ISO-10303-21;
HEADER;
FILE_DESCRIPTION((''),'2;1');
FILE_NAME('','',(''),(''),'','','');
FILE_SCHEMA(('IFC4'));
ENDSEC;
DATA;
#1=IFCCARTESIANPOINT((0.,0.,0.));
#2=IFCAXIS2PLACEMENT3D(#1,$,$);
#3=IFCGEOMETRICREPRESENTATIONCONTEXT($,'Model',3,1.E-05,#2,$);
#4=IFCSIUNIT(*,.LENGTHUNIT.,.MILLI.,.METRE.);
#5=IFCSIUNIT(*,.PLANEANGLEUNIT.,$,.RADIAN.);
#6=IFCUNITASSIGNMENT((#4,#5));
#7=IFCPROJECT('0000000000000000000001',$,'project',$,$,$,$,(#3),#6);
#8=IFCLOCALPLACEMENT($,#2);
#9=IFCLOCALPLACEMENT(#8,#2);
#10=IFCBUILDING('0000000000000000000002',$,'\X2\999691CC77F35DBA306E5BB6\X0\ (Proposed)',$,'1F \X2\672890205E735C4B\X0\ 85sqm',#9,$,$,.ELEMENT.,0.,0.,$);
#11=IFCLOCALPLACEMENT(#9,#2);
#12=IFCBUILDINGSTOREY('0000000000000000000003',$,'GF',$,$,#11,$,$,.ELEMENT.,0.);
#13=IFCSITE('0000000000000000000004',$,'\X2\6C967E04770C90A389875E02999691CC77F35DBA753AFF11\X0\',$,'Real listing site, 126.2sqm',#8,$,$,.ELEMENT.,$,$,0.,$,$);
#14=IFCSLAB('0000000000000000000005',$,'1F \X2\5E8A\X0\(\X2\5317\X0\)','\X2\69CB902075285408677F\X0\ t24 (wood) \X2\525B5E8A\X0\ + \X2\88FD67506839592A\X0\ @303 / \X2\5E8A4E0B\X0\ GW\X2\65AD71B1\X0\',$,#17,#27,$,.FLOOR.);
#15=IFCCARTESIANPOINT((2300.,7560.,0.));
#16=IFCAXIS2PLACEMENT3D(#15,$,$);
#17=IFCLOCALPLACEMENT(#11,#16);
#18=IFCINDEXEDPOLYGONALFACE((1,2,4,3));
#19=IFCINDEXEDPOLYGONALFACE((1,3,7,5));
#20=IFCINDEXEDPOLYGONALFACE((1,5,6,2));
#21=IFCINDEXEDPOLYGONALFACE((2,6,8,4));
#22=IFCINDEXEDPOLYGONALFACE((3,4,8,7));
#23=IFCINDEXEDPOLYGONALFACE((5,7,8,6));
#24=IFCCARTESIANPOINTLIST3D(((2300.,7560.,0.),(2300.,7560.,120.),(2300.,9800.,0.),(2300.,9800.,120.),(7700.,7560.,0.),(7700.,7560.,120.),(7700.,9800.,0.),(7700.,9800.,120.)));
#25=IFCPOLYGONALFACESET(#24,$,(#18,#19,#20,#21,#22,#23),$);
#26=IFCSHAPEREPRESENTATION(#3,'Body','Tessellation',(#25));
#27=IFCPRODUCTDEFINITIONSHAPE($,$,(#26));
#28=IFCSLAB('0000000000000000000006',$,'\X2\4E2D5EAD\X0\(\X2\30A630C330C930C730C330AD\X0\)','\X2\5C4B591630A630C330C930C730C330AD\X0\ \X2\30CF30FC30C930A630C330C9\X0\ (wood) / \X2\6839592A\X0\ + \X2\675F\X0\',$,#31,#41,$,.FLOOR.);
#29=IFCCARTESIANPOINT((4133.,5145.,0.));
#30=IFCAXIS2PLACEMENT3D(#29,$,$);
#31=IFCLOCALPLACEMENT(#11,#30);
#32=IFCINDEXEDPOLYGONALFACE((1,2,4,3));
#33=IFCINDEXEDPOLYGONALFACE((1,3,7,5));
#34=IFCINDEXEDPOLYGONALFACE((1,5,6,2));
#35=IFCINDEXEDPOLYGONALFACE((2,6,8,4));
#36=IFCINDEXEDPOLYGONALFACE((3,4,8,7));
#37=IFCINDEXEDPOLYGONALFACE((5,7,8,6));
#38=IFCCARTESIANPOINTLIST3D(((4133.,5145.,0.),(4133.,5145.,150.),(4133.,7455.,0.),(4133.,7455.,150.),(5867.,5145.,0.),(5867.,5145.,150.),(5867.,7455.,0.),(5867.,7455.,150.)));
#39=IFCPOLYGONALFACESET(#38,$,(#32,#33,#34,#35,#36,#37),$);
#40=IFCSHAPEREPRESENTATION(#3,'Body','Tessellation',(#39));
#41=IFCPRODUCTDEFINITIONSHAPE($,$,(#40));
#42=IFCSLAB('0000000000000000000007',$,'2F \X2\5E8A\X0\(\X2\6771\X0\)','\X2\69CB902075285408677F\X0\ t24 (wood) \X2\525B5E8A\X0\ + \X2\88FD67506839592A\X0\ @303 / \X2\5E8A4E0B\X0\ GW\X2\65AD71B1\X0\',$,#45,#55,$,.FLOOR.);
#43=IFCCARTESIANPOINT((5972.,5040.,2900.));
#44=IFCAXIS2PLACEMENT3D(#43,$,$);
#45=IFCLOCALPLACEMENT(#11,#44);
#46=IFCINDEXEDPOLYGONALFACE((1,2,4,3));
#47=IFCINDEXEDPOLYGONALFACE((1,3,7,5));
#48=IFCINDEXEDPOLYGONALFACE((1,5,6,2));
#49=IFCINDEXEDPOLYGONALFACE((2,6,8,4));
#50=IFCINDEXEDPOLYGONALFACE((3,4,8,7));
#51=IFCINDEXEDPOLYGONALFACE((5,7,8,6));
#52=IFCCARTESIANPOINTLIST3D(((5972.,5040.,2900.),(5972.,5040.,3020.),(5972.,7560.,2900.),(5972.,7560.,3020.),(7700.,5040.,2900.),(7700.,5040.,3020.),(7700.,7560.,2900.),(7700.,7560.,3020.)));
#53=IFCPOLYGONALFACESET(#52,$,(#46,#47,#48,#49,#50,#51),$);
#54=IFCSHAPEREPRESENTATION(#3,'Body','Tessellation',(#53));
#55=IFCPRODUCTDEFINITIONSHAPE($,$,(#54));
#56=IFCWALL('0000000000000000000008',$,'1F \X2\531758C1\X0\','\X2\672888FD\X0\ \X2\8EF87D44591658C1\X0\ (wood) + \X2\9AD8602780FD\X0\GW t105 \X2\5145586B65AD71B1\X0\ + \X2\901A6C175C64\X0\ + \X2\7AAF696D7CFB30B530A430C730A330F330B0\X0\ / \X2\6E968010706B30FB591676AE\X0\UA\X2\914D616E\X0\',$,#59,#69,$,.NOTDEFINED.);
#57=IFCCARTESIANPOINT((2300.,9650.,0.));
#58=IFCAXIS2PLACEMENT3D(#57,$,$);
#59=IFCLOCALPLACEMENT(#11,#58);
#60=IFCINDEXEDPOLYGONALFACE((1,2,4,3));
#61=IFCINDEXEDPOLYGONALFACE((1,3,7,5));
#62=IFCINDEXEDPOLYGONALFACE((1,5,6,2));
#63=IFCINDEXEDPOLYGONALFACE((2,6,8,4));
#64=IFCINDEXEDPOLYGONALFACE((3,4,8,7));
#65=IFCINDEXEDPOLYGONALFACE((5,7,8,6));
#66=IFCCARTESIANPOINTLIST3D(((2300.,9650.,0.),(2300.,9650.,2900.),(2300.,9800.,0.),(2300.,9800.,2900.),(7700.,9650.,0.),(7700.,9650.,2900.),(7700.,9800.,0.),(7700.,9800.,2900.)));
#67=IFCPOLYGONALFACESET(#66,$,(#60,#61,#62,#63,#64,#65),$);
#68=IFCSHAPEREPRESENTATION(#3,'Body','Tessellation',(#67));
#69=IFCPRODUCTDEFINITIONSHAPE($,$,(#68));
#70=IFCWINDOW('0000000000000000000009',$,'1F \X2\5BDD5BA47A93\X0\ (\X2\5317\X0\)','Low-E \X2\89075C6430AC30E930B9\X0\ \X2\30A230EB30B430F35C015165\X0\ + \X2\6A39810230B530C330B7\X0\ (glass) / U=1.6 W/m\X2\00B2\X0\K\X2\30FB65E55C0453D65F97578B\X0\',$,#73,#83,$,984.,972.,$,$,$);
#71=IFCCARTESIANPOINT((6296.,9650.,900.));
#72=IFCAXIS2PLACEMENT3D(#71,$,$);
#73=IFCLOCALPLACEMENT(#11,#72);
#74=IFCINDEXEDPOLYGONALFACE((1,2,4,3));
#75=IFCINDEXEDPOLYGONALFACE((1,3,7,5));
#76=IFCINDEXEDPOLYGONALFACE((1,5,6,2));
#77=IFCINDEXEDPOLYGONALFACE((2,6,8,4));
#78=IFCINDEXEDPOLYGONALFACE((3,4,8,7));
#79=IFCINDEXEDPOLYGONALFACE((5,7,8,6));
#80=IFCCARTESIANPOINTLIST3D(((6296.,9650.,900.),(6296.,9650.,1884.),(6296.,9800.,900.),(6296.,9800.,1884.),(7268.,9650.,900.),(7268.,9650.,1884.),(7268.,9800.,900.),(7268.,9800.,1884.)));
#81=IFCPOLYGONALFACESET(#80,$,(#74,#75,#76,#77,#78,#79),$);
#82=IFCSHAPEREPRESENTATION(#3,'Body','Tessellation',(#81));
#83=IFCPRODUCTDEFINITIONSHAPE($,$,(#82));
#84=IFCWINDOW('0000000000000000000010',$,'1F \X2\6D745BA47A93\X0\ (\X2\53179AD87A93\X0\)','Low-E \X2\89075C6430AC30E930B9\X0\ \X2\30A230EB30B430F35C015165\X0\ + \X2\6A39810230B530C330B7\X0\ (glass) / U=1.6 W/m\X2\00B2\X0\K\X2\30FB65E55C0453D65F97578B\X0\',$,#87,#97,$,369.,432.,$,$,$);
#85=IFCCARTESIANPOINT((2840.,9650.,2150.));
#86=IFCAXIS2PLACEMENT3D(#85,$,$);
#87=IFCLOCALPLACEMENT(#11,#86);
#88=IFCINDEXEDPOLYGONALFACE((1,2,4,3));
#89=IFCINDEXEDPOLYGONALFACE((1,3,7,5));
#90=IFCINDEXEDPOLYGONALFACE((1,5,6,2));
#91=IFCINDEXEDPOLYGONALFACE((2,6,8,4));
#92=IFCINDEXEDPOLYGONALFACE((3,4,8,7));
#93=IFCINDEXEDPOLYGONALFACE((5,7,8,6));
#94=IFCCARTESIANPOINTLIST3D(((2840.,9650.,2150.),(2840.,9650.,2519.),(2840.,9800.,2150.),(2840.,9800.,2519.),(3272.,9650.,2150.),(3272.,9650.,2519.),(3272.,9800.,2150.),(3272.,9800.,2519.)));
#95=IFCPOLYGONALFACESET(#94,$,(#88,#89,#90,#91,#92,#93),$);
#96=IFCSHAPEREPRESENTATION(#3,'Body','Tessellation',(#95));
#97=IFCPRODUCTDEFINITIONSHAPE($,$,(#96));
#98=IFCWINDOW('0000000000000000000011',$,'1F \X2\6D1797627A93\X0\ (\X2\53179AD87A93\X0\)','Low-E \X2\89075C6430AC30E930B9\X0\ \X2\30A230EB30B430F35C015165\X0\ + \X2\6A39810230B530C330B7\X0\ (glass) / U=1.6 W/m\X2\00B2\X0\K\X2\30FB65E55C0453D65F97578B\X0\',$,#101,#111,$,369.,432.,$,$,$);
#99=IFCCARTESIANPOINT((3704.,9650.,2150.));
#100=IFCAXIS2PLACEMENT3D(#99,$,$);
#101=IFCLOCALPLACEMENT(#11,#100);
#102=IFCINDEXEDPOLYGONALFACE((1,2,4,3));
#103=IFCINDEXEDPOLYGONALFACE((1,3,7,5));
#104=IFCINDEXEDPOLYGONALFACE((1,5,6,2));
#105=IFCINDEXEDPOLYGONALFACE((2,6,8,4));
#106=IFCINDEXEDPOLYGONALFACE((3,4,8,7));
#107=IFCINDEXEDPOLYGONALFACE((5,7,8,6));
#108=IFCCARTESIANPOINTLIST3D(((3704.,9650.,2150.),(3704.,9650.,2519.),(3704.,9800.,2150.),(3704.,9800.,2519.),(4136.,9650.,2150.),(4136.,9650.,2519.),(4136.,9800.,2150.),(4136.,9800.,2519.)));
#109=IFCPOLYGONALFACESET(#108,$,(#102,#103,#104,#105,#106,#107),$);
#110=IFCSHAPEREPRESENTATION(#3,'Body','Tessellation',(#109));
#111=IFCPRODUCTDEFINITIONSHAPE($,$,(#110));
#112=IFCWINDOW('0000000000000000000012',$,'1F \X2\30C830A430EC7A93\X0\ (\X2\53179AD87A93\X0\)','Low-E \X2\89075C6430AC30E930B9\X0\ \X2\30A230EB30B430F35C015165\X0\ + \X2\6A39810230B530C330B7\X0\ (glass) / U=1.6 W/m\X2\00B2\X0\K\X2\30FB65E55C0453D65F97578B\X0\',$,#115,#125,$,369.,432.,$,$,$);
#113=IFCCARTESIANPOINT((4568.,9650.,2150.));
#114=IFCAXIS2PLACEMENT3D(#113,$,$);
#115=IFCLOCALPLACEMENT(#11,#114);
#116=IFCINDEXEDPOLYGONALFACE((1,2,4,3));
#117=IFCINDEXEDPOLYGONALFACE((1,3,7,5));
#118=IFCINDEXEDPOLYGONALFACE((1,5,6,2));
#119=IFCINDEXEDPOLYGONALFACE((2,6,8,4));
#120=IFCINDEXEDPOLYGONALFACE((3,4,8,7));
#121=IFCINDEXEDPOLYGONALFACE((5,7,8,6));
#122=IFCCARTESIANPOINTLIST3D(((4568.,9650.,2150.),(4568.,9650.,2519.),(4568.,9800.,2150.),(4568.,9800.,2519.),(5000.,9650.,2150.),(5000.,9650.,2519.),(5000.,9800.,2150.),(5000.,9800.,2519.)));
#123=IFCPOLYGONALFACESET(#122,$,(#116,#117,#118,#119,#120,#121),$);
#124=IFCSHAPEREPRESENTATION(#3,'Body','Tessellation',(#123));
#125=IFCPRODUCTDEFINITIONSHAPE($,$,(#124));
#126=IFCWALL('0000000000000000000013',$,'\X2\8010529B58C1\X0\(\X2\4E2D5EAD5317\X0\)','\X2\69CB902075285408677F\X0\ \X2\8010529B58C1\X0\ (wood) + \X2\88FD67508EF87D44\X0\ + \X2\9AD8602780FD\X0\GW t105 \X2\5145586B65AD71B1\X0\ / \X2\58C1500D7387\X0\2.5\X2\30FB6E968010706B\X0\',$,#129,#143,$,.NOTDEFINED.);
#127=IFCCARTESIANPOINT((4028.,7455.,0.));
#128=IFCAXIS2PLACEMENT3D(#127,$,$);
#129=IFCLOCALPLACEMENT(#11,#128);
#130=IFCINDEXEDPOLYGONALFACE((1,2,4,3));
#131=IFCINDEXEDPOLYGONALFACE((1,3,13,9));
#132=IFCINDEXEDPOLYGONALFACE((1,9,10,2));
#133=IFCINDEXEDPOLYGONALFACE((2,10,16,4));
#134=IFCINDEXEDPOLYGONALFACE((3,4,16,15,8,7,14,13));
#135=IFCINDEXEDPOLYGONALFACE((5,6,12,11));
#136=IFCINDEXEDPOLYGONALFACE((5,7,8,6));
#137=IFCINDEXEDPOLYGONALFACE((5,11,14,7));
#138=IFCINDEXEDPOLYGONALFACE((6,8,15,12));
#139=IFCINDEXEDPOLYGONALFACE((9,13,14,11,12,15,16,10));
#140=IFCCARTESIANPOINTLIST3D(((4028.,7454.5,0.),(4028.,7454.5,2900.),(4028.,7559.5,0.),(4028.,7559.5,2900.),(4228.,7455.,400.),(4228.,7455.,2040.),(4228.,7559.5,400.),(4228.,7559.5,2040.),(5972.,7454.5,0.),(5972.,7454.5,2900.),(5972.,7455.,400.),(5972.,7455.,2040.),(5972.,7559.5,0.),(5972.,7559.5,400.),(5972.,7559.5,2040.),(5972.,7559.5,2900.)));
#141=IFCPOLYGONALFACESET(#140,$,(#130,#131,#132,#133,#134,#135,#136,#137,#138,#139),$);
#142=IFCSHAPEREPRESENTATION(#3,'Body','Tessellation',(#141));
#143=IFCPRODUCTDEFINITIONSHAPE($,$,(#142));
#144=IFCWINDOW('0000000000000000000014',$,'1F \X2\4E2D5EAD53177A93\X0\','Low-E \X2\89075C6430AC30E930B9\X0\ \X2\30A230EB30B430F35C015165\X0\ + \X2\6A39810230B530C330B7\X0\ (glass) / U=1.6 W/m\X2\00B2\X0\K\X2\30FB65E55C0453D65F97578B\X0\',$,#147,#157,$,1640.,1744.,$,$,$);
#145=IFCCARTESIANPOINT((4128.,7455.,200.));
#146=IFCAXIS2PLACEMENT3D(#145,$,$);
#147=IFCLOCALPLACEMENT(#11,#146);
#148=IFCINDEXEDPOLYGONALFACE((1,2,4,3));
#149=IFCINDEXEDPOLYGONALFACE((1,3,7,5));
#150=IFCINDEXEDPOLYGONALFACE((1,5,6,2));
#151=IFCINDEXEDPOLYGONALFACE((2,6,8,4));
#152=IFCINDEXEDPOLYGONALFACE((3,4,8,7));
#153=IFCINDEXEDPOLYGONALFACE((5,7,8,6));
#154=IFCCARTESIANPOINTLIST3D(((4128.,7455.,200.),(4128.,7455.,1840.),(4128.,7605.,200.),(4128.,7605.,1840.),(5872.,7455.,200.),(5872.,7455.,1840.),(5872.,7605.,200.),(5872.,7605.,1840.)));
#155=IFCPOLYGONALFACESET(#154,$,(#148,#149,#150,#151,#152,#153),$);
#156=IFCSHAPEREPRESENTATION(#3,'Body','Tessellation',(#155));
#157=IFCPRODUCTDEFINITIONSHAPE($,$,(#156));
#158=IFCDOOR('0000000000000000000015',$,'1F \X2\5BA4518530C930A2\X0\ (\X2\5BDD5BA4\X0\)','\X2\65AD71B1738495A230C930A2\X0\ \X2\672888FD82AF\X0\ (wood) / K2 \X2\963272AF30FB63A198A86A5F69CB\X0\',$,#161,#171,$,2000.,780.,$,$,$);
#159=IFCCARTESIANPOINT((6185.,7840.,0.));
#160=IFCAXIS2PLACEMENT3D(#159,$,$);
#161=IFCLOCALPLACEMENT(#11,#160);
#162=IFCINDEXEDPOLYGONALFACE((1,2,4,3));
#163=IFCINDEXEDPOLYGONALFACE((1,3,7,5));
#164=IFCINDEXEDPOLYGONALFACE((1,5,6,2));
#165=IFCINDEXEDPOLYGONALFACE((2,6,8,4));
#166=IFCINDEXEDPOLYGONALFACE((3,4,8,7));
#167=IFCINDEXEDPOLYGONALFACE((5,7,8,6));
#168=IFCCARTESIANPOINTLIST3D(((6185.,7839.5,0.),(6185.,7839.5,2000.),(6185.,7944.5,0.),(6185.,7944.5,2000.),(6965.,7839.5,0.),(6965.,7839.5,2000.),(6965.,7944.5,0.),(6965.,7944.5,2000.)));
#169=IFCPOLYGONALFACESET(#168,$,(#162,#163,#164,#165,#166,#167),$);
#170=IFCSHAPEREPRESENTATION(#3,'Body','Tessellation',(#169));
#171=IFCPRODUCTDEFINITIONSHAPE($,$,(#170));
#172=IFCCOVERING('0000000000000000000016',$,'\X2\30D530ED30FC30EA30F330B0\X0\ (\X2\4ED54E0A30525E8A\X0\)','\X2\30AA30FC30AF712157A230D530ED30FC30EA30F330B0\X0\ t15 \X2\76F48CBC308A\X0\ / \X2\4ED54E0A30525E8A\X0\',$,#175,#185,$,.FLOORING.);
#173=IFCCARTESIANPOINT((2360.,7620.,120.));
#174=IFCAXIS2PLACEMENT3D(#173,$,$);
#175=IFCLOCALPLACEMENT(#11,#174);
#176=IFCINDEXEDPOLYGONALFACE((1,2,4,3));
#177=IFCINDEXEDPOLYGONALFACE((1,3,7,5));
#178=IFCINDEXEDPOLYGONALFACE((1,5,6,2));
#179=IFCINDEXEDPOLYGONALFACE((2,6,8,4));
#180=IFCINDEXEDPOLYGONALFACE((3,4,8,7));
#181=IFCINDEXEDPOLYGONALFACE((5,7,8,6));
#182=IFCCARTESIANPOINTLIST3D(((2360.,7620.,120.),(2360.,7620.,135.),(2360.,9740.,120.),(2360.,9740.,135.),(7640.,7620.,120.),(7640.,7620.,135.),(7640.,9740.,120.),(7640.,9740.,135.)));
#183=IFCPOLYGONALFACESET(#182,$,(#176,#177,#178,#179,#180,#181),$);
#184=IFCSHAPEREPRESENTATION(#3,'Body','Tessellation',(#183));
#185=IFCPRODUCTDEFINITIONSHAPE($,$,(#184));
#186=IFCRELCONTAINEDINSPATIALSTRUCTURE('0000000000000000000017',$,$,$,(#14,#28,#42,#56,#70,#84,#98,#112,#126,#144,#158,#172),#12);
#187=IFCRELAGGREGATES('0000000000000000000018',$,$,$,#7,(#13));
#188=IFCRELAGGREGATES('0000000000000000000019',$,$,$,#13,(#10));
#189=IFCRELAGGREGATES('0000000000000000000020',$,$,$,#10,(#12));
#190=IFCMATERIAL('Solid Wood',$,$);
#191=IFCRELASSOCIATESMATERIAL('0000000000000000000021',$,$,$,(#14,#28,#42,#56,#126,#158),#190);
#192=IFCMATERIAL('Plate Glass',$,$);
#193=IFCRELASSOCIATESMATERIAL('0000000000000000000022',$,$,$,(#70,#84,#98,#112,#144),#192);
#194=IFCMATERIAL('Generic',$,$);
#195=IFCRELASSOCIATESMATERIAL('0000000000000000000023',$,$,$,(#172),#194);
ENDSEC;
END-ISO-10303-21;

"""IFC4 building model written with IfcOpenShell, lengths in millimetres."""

from ifc_helpers import new_model, si_unit, frame, frame_2d, origin, place, context, project, spatial, rectangle, extrude, material, element, fill, save


model = new_model("IFC4")

# Units and contexts
model_context = context("Model", 3, precision=1e-05, world=origin())
ifc_project = project(units=[si_unit("LENGTHUNIT", "METRE", prefix="MILLI"), si_unit("PLANEANGLEUNIT", "RADIAN")], contexts=[model_context])

# Site, building, storey
site_placement = place(None, origin())
site = spatial("IfcSite", under=ifc_project, at=site_placement, Name="沖縄県那覇市首里石嶺町１", ObjectType="Real listing site, 126.2sqm", CompositionType="ELEMENT", RefElevation=0.0)
building_placement = place(site_placement, origin())
building = spatial("IfcBuilding", under=site, at=building_placement, Name="首里石嶺の家 (Proposed)", ObjectType="1F 木造平屋 85sqm", CompositionType="ELEMENT", ElevationOfRefHeight=0.0, ElevationOfTerrain=0.0)
storey_placement = place(building_placement, origin())
storey = spatial("IfcBuildingStorey", under=building, at=storey_placement, Name="GF", CompositionType="ELEMENT", Elevation=0.0)

# Slabs
ifc_material_1 = material(Name="Solid Wood")
slab_1_placement = place(storey_placement, frame((2300.0, 7560.0, 0.0)))
element("IfcSlab", 1, at=slab_1_placement, inside=storey, material=ifc_material_1, Name="1F 床(北)", Description="構造用合板 t24 (wood) 剛床 + 製材根太 @303 / 床下 GW断熱", PredefinedType="FLOOR", context=model_context, shape_type="SweptSolid", body=[
    extrude(rectangle(XDim=5400.0, YDim=2240.0, at=frame_2d((2700.0, 1120.0))), frame((2300.0, 7560.0, 0.0)), (0.0, 0.0, 1.0), 120.0),
])
slab_2_placement = place(storey_placement, frame((4133.0, 5145.0, 0.0)))
element("IfcSlab", 2, at=slab_2_placement, inside=storey, material=ifc_material_1, Name="中庭(ウッドデッキ)", Description="屋外ウッドデッキ ハードウッド (wood) / 根太 + 束", PredefinedType="FLOOR", context=model_context, shape_type="SweptSolid", body=[
    extrude(rectangle(XDim=1734.0, YDim=2310.0, at=frame_2d((867.0, 1155.0))), frame((4133.0, 5145.0, 0.0)), (0.0, 0.0, 1.0), 150.0),
])
slab_3_placement = place(storey_placement, frame((5972.0, 5040.0, 2900.0)))
element("IfcSlab", 3, at=slab_3_placement, inside=storey, material=ifc_material_1, Name="2F 床(東)", Description="構造用合板 t24 (wood) 剛床 + 製材根太 @303 / 床下 GW断熱", PredefinedType="FLOOR", context=model_context, shape_type="SweptSolid", body=[
    extrude(rectangle(XDim=1728.0, YDim=2520.0, at=frame_2d((864.0, 1260.0))), frame((5972.0, 5040.0, 2900.0)), (0.0, 0.0, 1.0), 120.0),
])

# Wall, openings, windows
wall_1_placement = place(storey_placement, frame((2300.0, 9650.0, 0.0)))
wall_1 = element("IfcWall", 4, at=wall_1_placement, inside=storey, material=ifc_material_1, Name="1F 北壁", Description="木製 軸組外壁 (wood) + 高性能GW t105 充填断熱 + 通気層 + 窯業系サイディング / 準耐火・外皮UA配慮", PredefinedType="NOTDEFINED", context=model_context, shape_type="SweptSolid", body=[
    extrude(rectangle(XDim=5400.0, YDim=150.0, at=frame_2d((2700.0, 75.0))), frame((2300.0, 9650.0, 0.0)), (0.0, 0.0, 1.0), 2900.0),
])
opening_1_placement = place(storey_placement, frame((6296.0, 9650.0, 900.0)))
opening_1 = element("IfcOpeningElement", 5, at=opening_1_placement, cuts=wall_1, PredefinedType="NOTDEFINED", context=model_context, shape_type="SweptSolid", body=[
    extrude(rectangle(XDim=972.0, YDim=150.0, at=frame_2d((486.0, 75.0))), frame((6296.0, 9650.0, 900.0)), (0.0, 0.0, 1.0), 984.0),
])
opening_2_placement = place(storey_placement, frame((2840.0, 9650.0, 2150.0)))
opening_2 = element("IfcOpeningElement", 6, at=opening_2_placement, cuts=wall_1, PredefinedType="NOTDEFINED", context=model_context, shape_type="SweptSolid", body=[
    extrude(rectangle(XDim=432.0, YDim=150.0, at=frame_2d((216.0, 75.0))), frame((2840.0, 9650.0, 2150.0)), (0.0, 0.0, 1.0), 369.0),
])
opening_3_placement = place(storey_placement, frame((3704.0, 9650.0, 2150.0)))
opening_3 = element("IfcOpeningElement", 7, at=opening_3_placement, cuts=wall_1, PredefinedType="NOTDEFINED", context=model_context, shape_type="SweptSolid", body=[
    extrude(rectangle(XDim=432.0, YDim=150.0, at=frame_2d((216.0, 75.0))), frame((3704.0, 9650.0, 2150.0)), (0.0, 0.0, 1.0), 369.0),
])
opening_4_placement = place(storey_placement, frame((4568.0, 9650.0, 2150.0)))
opening_4 = element("IfcOpeningElement", 8, at=opening_4_placement, cuts=wall_1, PredefinedType="NOTDEFINED", context=model_context, shape_type="SweptSolid", body=[
    extrude(rectangle(XDim=432.0, YDim=150.0, at=frame_2d((216.0, 75.0))), frame((4568.0, 9650.0, 2150.0)), (0.0, 0.0, 1.0), 369.0),
])
ifc_material_2 = material(Name="Plate Glass")
window_1_placement = place(storey_placement, frame((6296.0, 9650.0, 900.0)))
window_1 = element("IfcWindow", 9, at=window_1_placement, inside=storey, material=ifc_material_2, Name="1F 寝室窓 (北)", Description="Low-E 複層ガラス アルゴン封入 + 樹脂サッシ (glass) / U=1.6 W/m²K・日射取得型", OverallHeight=984.0, OverallWidth=972.0, context=model_context, shape_type="SweptSolid", body=[
    extrude(rectangle(XDim=972.0, YDim=150.0, at=frame_2d((486.0, 75.0))), frame((6296.0, 9650.0, 900.0)), (0.0, 0.0, 1.0), 984.0),
])
fill(opening_1, window_1)
window_2_placement = place(storey_placement, frame((2840.0, 9650.0, 2150.0)))
window_2 = element("IfcWindow", 10, at=window_2_placement, inside=storey, material=ifc_material_2, Name="1F 浴室窓 (北高窓)", Description="Low-E 複層ガラス アルゴン封入 + 樹脂サッシ (glass) / U=1.6 W/m²K・日射取得型", OverallHeight=369.0, OverallWidth=432.0, context=model_context, shape_type="SweptSolid", body=[
    extrude(rectangle(XDim=432.0, YDim=150.0, at=frame_2d((216.0, 75.0))), frame((2840.0, 9650.0, 2150.0)), (0.0, 0.0, 1.0), 369.0),
])
fill(opening_2, window_2)
window_3_placement = place(storey_placement, frame((3704.0, 9650.0, 2150.0)))
window_3 = element("IfcWindow", 11, at=window_3_placement, inside=storey, material=ifc_material_2, Name="1F 洗面窓 (北高窓)", Description="Low-E 複層ガラス アルゴン封入 + 樹脂サッシ (glass) / U=1.6 W/m²K・日射取得型", OverallHeight=369.0, OverallWidth=432.0, context=model_context, shape_type="SweptSolid", body=[
    extrude(rectangle(XDim=432.0, YDim=150.0, at=frame_2d((216.0, 75.0))), frame((3704.0, 9650.0, 2150.0)), (0.0, 0.0, 1.0), 369.0),
])
fill(opening_3, window_3)
window_4_placement = place(storey_placement, frame((4568.0, 9650.0, 2150.0)))
window_4 = element("IfcWindow", 12, at=window_4_placement, inside=storey, material=ifc_material_2, Name="1F トイレ窓 (北高窓)", Description="Low-E 複層ガラス アルゴン封入 + 樹脂サッシ (glass) / U=1.6 W/m²K・日射取得型", OverallHeight=369.0, OverallWidth=432.0, context=model_context, shape_type="SweptSolid", body=[
    extrude(rectangle(XDim=432.0, YDim=150.0, at=frame_2d((216.0, 75.0))), frame((4568.0, 9650.0, 2150.0)), (0.0, 0.0, 1.0), 369.0),
])
fill(opening_4, window_4)

# Wall, opening, window
wall_2_placement = place(storey_placement, frame((4028.0, 7455.0, 0.0)))
wall_2 = element("IfcWall", 13, at=wall_2_placement, inside=storey, material=ifc_material_1, Name="耐力壁(中庭北)", Description="構造用合板 耐力壁 (wood) + 製材軸組 + 高性能GW t105 充填断熱 / 壁倍率2.5・準耐火", PredefinedType="NOTDEFINED", context=model_context, shape_type="SweptSolid", body=[
    extrude(rectangle(XDim=1944.0, YDim=105.0, at=frame_2d((972.0, 52.0))), frame((4028.0, 7455.0, 0.0)), (0.0, 0.0, 1.0), 2900.0),
])
opening_5_placement = place(storey_placement, frame((4128.0, 7455.0, 200.0)))
opening_5 = element("IfcOpeningElement", 14, at=opening_5_placement, cuts=wall_2, PredefinedType="NOTDEFINED", context=model_context, shape_type="SweptSolid", body=[
    extrude(rectangle(XDim=1744.0, YDim=150.0, at=frame_2d((872.0, 75.0))), frame((4128.0, 7455.0, 200.0)), (0.0, 0.0, 1.0), 1640.0),
])
window_5_placement = place(storey_placement, frame((4128.0, 7455.0, 200.0)))
window_5 = element("IfcWindow", 15, at=window_5_placement, inside=storey, material=ifc_material_2, Name="1F 中庭北窓", Description="Low-E 複層ガラス アルゴン封入 + 樹脂サッシ (glass) / U=1.6 W/m²K・日射取得型", OverallHeight=1640.0, OverallWidth=1744.0, context=model_context, shape_type="SweptSolid", body=[
    extrude(rectangle(XDim=1744.0, YDim=150.0, at=frame_2d((872.0, 75.0))), frame((4128.0, 7455.0, 200.0)), (0.0, 0.0, 1.0), 1640.0),
])
fill(opening_5, window_5)

# Door
door_1_placement = place(storey_placement, frame((6185.0, 7840.0, 0.0)))
element("IfcDoor", 16, at=door_1_placement, inside=storey, material=ifc_material_1, Name="1F 室内ドア (寝室)", Description="断熱玄関ドア 木製芯 (wood) / K2 防犯・採風機構", OverallHeight=2000.0, OverallWidth=780.0, context=model_context, shape_type="SweptSolid", body=[
    extrude(rectangle(XDim=780.0, YDim=105.0, at=frame_2d((390.0, 52.0))), frame((6185.0, 7840.0, 0.0)), (0.0, 0.0, 1.0), 2000.0),
])

# Covering
ifc_material_3 = material(Name="Generic")
covering_1_placement = place(storey_placement, frame((2360.0, 7620.0, 120.0)))
element("IfcCovering", 17, at=covering_1_placement, inside=storey, material=ifc_material_3, Name="フローリング (仕上げ床)", Description="オーク無垢フローリング t15 直貼り / 仕上げ床", PredefinedType="FLOORING", context=model_context, shape_type="SweptSolid", body=[
    extrude(rectangle(XDim=5280.0, YDim=2120.0, at=frame_2d((2640.0, 1060.0))), frame((2360.0, 7620.0, 120.0)), (0.0, 0.0, 1.0), 15.0),
])

save(model, "model.ifc")
